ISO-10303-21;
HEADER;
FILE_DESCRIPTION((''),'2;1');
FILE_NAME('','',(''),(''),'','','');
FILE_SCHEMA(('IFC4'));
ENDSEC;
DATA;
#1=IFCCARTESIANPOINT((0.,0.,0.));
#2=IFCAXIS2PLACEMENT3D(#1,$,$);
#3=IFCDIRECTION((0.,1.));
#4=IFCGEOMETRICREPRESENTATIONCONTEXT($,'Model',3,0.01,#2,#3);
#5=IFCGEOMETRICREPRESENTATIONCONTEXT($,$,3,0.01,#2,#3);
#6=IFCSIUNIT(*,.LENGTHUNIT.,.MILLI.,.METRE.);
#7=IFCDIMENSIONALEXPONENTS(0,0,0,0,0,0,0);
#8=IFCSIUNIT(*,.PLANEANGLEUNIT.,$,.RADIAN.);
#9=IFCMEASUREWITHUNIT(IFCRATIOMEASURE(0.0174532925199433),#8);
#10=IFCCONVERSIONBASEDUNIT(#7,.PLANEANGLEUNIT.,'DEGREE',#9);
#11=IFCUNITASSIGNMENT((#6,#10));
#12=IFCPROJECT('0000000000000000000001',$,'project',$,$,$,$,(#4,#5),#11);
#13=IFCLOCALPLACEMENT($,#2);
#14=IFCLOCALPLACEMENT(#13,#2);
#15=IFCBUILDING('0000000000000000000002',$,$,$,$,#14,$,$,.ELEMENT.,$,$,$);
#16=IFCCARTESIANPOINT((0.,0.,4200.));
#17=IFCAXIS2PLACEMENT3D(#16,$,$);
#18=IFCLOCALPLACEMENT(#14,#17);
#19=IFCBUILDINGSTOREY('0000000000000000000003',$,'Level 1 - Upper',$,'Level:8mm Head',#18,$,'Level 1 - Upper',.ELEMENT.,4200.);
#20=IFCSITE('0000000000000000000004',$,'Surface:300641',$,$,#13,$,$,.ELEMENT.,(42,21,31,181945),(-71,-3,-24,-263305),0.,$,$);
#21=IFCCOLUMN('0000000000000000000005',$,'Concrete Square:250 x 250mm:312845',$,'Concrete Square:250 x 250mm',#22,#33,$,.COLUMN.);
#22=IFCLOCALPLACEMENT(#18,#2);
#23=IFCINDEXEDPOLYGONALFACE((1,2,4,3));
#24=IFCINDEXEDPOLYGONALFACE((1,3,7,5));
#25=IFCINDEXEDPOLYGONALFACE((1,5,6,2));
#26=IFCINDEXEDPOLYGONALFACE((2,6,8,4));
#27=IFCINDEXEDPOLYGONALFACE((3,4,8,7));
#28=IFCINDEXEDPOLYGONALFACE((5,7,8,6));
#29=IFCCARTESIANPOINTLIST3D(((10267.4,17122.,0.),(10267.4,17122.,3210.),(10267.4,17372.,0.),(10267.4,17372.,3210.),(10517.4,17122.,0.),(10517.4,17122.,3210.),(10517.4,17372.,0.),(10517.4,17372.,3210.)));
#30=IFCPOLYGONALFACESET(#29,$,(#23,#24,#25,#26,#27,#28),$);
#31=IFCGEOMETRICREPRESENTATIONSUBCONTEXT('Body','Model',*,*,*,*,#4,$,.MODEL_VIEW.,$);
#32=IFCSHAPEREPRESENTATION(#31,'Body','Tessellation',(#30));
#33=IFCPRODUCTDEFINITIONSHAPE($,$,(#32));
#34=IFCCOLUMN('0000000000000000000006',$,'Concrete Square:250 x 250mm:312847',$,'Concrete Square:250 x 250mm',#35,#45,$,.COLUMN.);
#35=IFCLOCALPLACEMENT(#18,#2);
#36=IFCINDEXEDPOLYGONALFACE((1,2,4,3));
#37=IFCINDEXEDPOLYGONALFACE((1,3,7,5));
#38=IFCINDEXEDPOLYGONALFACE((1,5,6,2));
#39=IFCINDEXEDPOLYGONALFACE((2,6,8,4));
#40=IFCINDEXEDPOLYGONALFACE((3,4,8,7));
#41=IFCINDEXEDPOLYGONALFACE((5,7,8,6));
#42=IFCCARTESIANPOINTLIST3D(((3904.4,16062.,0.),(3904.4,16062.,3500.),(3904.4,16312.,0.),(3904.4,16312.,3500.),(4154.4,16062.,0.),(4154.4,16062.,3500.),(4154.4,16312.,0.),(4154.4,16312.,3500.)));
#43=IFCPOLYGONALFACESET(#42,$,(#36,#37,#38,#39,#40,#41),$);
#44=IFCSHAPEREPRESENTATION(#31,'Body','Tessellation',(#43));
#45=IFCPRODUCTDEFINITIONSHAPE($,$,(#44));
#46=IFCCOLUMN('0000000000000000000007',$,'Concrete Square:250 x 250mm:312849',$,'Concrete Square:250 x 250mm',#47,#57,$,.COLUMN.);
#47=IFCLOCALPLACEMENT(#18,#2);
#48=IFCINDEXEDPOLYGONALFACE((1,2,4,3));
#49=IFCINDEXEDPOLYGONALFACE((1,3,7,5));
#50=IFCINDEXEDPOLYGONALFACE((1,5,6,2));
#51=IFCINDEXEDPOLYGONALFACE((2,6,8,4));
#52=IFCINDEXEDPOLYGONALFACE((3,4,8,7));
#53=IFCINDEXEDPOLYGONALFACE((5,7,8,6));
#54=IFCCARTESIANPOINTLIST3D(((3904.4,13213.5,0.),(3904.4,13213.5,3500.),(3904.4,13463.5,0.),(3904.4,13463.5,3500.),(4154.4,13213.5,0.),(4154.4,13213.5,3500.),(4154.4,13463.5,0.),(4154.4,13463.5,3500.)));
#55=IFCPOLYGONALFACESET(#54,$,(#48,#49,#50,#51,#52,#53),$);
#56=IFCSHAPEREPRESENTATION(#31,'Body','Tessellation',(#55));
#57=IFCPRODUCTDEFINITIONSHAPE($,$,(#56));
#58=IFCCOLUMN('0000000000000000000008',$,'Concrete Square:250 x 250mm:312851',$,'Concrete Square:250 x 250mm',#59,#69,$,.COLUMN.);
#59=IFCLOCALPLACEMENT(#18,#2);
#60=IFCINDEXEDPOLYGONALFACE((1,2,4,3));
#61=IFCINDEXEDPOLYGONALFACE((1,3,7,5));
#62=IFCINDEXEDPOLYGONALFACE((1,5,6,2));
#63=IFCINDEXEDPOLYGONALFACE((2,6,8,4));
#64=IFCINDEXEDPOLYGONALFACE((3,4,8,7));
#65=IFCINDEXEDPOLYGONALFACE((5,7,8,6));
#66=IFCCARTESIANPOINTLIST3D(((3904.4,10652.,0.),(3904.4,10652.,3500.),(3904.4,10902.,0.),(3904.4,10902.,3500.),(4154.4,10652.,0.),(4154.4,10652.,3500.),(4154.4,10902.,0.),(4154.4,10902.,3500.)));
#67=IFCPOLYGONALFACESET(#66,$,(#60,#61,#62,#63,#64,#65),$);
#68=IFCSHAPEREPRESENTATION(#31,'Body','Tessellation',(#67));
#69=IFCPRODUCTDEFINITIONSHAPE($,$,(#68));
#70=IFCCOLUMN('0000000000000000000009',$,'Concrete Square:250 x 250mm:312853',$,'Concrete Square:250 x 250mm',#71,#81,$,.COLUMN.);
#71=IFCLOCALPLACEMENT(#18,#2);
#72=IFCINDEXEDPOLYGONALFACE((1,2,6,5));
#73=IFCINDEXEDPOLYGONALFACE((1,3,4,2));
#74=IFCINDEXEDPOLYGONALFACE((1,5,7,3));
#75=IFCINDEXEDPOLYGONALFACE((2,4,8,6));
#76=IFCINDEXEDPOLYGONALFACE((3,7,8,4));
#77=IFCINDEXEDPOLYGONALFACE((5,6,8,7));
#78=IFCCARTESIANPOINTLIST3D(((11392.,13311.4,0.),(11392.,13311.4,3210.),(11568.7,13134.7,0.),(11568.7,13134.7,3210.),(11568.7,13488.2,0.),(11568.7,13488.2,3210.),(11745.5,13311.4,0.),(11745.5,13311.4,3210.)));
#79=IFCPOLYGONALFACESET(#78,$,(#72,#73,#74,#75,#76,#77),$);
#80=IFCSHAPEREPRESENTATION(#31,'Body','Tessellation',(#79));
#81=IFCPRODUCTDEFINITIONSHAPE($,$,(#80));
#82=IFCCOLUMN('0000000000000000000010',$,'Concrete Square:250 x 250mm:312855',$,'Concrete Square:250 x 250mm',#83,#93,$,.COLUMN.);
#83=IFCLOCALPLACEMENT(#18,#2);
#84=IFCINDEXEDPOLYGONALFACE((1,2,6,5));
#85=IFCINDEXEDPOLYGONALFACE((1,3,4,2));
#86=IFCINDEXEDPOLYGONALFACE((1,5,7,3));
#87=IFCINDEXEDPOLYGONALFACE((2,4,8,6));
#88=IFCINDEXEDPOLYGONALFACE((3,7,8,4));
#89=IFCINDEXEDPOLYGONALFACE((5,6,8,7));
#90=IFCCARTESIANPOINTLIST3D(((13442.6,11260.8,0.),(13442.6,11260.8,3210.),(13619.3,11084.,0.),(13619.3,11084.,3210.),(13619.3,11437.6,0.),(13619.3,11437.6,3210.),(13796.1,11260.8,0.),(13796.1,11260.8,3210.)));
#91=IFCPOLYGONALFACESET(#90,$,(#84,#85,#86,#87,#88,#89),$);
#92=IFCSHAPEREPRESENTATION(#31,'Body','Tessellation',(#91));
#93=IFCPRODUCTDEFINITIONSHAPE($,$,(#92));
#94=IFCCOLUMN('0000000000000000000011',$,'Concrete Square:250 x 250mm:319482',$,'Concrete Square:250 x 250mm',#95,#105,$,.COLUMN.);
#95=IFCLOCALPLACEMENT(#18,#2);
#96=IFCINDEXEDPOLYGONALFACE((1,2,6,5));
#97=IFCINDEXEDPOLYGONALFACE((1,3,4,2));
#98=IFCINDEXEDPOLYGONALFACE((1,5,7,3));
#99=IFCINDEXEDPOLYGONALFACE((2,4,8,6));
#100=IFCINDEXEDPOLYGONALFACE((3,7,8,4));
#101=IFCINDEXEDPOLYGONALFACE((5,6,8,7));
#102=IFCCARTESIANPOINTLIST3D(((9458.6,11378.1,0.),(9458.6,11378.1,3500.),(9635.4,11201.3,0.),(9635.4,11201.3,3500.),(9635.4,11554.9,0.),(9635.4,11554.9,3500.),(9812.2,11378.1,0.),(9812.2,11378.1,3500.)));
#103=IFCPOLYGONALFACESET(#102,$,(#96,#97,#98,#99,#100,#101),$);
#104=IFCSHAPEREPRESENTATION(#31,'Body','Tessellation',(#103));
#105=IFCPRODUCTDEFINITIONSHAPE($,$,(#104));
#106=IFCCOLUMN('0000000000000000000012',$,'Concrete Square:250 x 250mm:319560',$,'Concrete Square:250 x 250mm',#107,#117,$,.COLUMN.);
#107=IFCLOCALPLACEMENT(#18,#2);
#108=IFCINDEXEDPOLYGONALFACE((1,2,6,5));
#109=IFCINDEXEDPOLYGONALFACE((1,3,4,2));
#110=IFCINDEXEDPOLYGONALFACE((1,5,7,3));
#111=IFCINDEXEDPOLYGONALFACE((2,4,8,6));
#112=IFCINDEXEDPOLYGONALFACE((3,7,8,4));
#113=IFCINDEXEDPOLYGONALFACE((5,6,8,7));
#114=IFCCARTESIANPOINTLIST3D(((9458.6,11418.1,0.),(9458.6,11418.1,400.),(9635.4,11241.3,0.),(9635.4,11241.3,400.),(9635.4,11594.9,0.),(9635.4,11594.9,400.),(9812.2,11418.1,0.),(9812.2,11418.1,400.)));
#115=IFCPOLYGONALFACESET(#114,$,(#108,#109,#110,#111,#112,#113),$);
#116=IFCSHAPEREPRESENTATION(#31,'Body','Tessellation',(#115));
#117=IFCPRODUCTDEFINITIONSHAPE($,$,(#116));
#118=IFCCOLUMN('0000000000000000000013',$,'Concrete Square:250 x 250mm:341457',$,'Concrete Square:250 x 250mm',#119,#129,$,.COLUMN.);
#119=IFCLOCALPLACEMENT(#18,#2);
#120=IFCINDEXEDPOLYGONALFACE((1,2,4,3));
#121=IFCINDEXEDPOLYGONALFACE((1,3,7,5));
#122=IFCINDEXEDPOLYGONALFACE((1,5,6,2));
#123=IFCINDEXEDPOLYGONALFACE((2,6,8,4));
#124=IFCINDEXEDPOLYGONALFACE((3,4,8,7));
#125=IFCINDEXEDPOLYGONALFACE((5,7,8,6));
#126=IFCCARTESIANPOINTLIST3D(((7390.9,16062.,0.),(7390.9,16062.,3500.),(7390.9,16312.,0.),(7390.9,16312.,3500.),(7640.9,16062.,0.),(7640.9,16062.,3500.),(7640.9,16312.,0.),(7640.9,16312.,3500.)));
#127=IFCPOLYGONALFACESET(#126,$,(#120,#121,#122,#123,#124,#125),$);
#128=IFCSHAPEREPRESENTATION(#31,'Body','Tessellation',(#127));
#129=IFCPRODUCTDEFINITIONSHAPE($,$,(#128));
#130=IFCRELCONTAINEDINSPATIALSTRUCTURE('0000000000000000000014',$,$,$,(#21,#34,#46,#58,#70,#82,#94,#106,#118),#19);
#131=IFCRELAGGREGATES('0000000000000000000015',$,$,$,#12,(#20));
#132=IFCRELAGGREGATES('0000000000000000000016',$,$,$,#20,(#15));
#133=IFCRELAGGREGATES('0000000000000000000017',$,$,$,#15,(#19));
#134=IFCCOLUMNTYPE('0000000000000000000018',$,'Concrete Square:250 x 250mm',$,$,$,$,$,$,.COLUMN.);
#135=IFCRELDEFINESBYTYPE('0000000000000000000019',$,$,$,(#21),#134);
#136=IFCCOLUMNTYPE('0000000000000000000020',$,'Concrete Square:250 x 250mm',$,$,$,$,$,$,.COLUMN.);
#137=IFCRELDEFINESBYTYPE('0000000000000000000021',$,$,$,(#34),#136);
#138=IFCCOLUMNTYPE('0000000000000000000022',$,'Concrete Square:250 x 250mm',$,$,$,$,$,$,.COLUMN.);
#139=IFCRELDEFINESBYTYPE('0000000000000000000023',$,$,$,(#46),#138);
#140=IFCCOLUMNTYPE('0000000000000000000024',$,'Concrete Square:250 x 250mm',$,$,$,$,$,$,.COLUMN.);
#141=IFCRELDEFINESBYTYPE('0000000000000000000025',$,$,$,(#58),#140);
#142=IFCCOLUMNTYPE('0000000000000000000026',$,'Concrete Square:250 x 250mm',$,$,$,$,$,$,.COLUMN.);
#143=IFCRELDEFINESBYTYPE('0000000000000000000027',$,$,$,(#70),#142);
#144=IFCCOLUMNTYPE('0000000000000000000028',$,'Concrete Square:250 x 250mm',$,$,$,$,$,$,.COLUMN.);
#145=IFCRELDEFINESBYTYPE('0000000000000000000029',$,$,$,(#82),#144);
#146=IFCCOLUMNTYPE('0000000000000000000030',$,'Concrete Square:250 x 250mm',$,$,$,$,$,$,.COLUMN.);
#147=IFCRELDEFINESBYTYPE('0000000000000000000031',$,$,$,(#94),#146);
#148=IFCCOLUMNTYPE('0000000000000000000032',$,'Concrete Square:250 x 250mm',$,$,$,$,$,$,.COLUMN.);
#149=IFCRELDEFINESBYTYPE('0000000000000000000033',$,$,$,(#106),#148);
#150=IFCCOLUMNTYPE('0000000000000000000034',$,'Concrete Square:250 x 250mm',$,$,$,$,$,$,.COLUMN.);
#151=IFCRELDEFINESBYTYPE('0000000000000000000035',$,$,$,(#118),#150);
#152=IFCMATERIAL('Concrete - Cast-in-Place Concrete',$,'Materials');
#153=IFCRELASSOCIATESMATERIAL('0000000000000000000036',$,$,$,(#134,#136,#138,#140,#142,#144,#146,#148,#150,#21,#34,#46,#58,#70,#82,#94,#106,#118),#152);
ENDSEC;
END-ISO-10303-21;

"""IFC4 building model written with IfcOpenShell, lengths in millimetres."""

from ifc_helpers import new_model, entity, si_unit, converted_unit, direction, frame, frame_2d, origin, origin_2d_with_axis, place, context, subcontext, project, spatial, rectangle, extrude, source, transform, mapped, material, material_profile, profile_set, profile_usage, type_object, type_shapes, element, save


model = new_model("IFC4")

# Units and contexts
model_context = context("Model", 3, precision=0.01, world=origin(), true_north=direction((0.0, 1.0)))
context_of_model = context(None, 3, precision=0.01, world=origin(), true_north=direction((0.0, 1.0)))
body_context = subcontext(model_context, "Body", "Model", "MODEL_VIEW")
ifc_project = project(units=[si_unit("LENGTHUNIT", "METRE", prefix="MILLI"), converted_unit("PLANEANGLEUNIT", "DEGREE", entity("IfcRatioMeasure", 0.0174532925199433), si_unit("PLANEANGLEUNIT", "RADIAN"), dimensions=[0, 0, 0, 0, 0, 0, 0])], contexts=[model_context, context_of_model])

# Site, building, storey
site_placement = place(None, origin())
site = spatial("IfcSite", under=ifc_project, at=site_placement, Name="Surface:300641", CompositionType="ELEMENT", RefLatitude=(42, 21, 31, 181945), RefLongitude=(-71, -3, -24, -263305), RefElevation=0.0)
building_placement = place(site_placement, origin())
building = spatial("IfcBuilding", under=site, at=building_placement, CompositionType="ELEMENT")
storey_placement = place(building_placement, frame((0.0, 0.0, 4200.0)))
storey = spatial("IfcBuildingStorey", under=building, at=storey_placement, Name="Level 1 - Upper", ObjectType="Level:8mm Head", LongName="Level 1 - Upper", CompositionType="ELEMENT", Elevation=4200.0)

# Columns
ifc_material = material(Name="Concrete - Cast-in-Place Concrete", Category="Materials")
ifc_material_profile_1 = material_profile(ifc_material, rectangle(XDim=250.0, YDim=250.0, at=frame_2d((0.0, 0.0), x_axis=(1.0, 0.0))), Name="250 x 250mm")
ifc_profile_set_1 = profile_set([ifc_material_profile_1], Name="250 x 250mm")
ifc_profile_usage_1 = profile_usage(ifc_profile_set_1)
column_type_1 = type_object("IfcColumnType", Name="Concrete Square:250 x 250mm", PredefinedType="COLUMN", material=ifc_profile_set_1)
shared_shape_1 = source(origin(), body_context, "Body", "SweptSolid", [
    extrude(rectangle(XDim=250.0, YDim=250.0, at=origin_2d_with_axis()), frame((10392.4, 17247.0, 4200.0), z_axis=(0.0, 0.0, 1.0), x_axis=(0.0, -1.0, 0.0)), (0.0, 0.0, 1.0), 3210.0),
])
type_shapes(column_type_1, [shared_shape_1])
column_1_placement = place(storey_placement, frame((0.0, 0.0, -4200.0)))
element("IfcColumn", 1, at=column_1_placement, inside=storey, type_object=column_type_1, material=ifc_profile_usage_1, Name="Concrete Square:250 x 250mm:312845", ObjectType="Concrete Square:250 x 250mm", PredefinedType="COLUMN", context=body_context, shape_type="MappedRepresentation", body=[
    mapped(shared_shape_1, transform((0.0, 0.0, 0.0), scale=1.0)),
])
ifc_profile_usage_2 = profile_usage(ifc_profile_set_1)
column_type_2 = type_object("IfcColumnType", Name="Concrete Square:250 x 250mm", PredefinedType="COLUMN", material=ifc_profile_set_1)
shared_shape_2 = source(origin(), body_context, "Body", "SweptSolid", [
    extrude(rectangle(XDim=250.0, YDim=250.0, at=frame_2d((0.0, 0.0), x_axis=(1.0, 0.0))), frame((4029.4, 16187.0, 4200.0), z_axis=(0.0, 0.0, 1.0), x_axis=(0.0, -1.0, 0.0)), (0.0, 0.0, 1.0), 3500.0),
])
type_shapes(column_type_2, [shared_shape_2])
column_2_placement = place(storey_placement, frame((0.0, 0.0, -4200.0)))
element("IfcColumn", 2, at=column_2_placement, inside=storey, type_object=column_type_2, material=ifc_profile_usage_2, Name="Concrete Square:250 x 250mm:312847", ObjectType="Concrete Square:250 x 250mm", PredefinedType="COLUMN", context=body_context, shape_type="MappedRepresentation", body=[
    mapped(shared_shape_2, transform((0.0, 0.0, 0.0), scale=1.0)),
])
ifc_profile_usage_3 = profile_usage(ifc_profile_set_1)
column_type_3 = type_object("IfcColumnType", Name="Concrete Square:250 x 250mm", PredefinedType="COLUMN", material=ifc_profile_set_1)
shared_shape_3 = source(origin(), body_context, "Body", "SweptSolid", [
    extrude(rectangle(XDim=250.0, YDim=250.0, at=frame_2d((0.0, 0.0), x_axis=(1.0, 0.0))), frame((4029.4, 13338.5, 4200.0), z_axis=(0.0, 0.0, 1.0), x_axis=(0.0, -1.0, 0.0)), (0.0, 0.0, 1.0), 3500.0),
])
type_shapes(column_type_3, [shared_shape_3])
column_3_placement = place(storey_placement, frame((0.0, 0.0, -4200.0)))
element("IfcColumn", 3, at=column_3_placement, inside=storey, type_object=column_type_3, material=ifc_profile_usage_3, Name="Concrete Square:250 x 250mm:312849", ObjectType="Concrete Square:250 x 250mm", PredefinedType="COLUMN", context=body_context, shape_type="MappedRepresentation", body=[
    mapped(shared_shape_3, transform((0.0, 0.0, 0.0), scale=1.0)),
])
ifc_profile_usage_4 = profile_usage(ifc_profile_set_1)
column_type_4 = type_object("IfcColumnType", Name="Concrete Square:250 x 250mm", PredefinedType="COLUMN", material=ifc_profile_set_1)
shared_shape_4 = source(origin(), body_context, "Body", "SweptSolid", [
    extrude(rectangle(XDim=250.0, YDim=250.0, at=frame_2d((0.0, 0.0), x_axis=(1.0, 0.0))), frame((4029.4, 10777.0, 4200.0), z_axis=(0.0, 0.0, 1.0), x_axis=(0.0, -1.0, 0.0)), (0.0, 0.0, 1.0), 3500.0),
])
type_shapes(column_type_4, [shared_shape_4])
column_4_placement = place(storey_placement, frame((0.0, 0.0, -4200.0)))
element("IfcColumn", 4, at=column_4_placement, inside=storey, type_object=column_type_4, material=ifc_profile_usage_4, Name="Concrete Square:250 x 250mm:312851", ObjectType="Concrete Square:250 x 250mm", PredefinedType="COLUMN", context=body_context, shape_type="MappedRepresentation", body=[
    mapped(shared_shape_4, transform((0.0, 0.0, 0.0), scale=1.0)),
])
ifc_profile_usage_5 = profile_usage(ifc_profile_set_1)
column_type_5 = type_object("IfcColumnType", Name="Concrete Square:250 x 250mm", PredefinedType="COLUMN", material=ifc_profile_set_1)
shared_shape_5 = source(origin(), body_context, "Body", "SweptSolid", [
    extrude(rectangle(XDim=250.0, YDim=250.0, at=origin_2d_with_axis()), frame((11568.7, 13311.4, 4200.0), z_axis=(0.0, 0.0, 1.0), x_axis=(-0.707107, 0.707107, 0.0)), (0.0, 0.0, 1.0), 3210.0),
])
type_shapes(column_type_5, [shared_shape_5])
column_5_placement = place(storey_placement, frame((0.0, 0.0, -4200.0)))
element("IfcColumn", 5, at=column_5_placement, inside=storey, type_object=column_type_5, material=ifc_profile_usage_5, Name="Concrete Square:250 x 250mm:312853", ObjectType="Concrete Square:250 x 250mm", PredefinedType="COLUMN", context=body_context, shape_type="MappedRepresentation", body=[
    mapped(shared_shape_5, transform((0.0, 0.0, 0.0), scale=1.0)),
])
ifc_profile_usage_6 = profile_usage(ifc_profile_set_1)
column_type_6 = type_object("IfcColumnType", Name="Concrete Square:250 x 250mm", PredefinedType="COLUMN", material=ifc_profile_set_1)
shared_shape_6 = source(origin(), body_context, "Body", "SweptSolid", [
    extrude(rectangle(XDim=250.0, YDim=250.0, at=frame_2d((0.0, 0.0), x_axis=(1.0, 0.0))), frame((13619.3, 11260.8, 4200.0), z_axis=(0.0, 0.0, 1.0), x_axis=(-0.707107, 0.707107, 0.0)), (0.0, 0.0, 1.0), 3210.0),
])
type_shapes(column_type_6, [shared_shape_6])
column_6_placement = place(storey_placement, frame((0.0, 0.0, -4200.0)))
element("IfcColumn", 6, at=column_6_placement, inside=storey, type_object=column_type_6, material=ifc_profile_usage_6, Name="Concrete Square:250 x 250mm:312855", ObjectType="Concrete Square:250 x 250mm", PredefinedType="COLUMN", context=body_context, shape_type="MappedRepresentation", body=[
    mapped(shared_shape_6, transform((0.0, 0.0, 0.0), scale=1.0)),
])
ifc_profile_usage_7 = profile_usage(ifc_profile_set_1)
column_type_7 = type_object("IfcColumnType", Name="Concrete Square:250 x 250mm", PredefinedType="COLUMN", material=ifc_profile_set_1)
shared_shape_7 = source(origin(), body_context, "Body", "SweptSolid", [
    extrude(rectangle(XDim=250.0, YDim=250.0, at=frame_2d((0.0, 0.0), x_axis=(1.0, 0.0))), frame((9635.4, 11378.1, 4200.0), z_axis=(0.0, 0.0, 1.0), x_axis=(-0.707107, 0.707107, 0.0)), (0.0, 0.0, 1.0), 3500.0),
])
type_shapes(column_type_7, [shared_shape_7])
column_7_placement = place(storey_placement, frame((0.0, 0.0, -4200.0)))
element("IfcColumn", 7, at=column_7_placement, inside=storey, type_object=column_type_7, material=ifc_profile_usage_7, Name="Concrete Square:250 x 250mm:319482", ObjectType="Concrete Square:250 x 250mm", PredefinedType="COLUMN", context=body_context, shape_type="MappedRepresentation", body=[
    mapped(shared_shape_7, transform((0.0, 0.0, 0.0), scale=1.0)),
])
ifc_profile_usage_8 = profile_usage(ifc_profile_set_1)
column_type_8 = type_object("IfcColumnType", Name="Concrete Square:250 x 250mm", PredefinedType="COLUMN", material=ifc_profile_set_1)
shared_shape_8 = source(origin(), body_context, "Body", "SweptSolid", [
    extrude(rectangle(XDim=250.0, YDim=250.0, at=frame_2d((0.0, 0.0), x_axis=(1.0, 0.0))), frame((9635.4, 11418.1, 4200.0), z_axis=(0.0, 0.0, 1.0), x_axis=(-0.707107, 0.707107, 0.0)), (0.0, 0.0, 1.0), 400.0),
])
type_shapes(column_type_8, [shared_shape_8])
column_8_placement = place(storey_placement, frame((0.0, 0.0, -4200.0)))
element("IfcColumn", 8, at=column_8_placement, inside=storey, type_object=column_type_8, material=ifc_profile_usage_8, Name="Concrete Square:250 x 250mm:319560", ObjectType="Concrete Square:250 x 250mm", PredefinedType="COLUMN", context=body_context, shape_type="MappedRepresentation", body=[
    mapped(shared_shape_8, transform((0.0, 0.0, 0.0), scale=1.0)),
])
ifc_profile_usage_9 = profile_usage(ifc_profile_set_1)
column_type_9 = type_object("IfcColumnType", Name="Concrete Square:250 x 250mm", PredefinedType="COLUMN", material=ifc_profile_set_1)
shared_shape_9 = source(origin(), body_context, "Body", "SweptSolid", [
    extrude(rectangle(XDim=250.0, YDim=250.0, at=frame_2d((0.0, 0.0), x_axis=(1.0, 0.0))), frame((7515.9, 16187.0, 4200.0), z_axis=(0.0, 0.0, 1.0), x_axis=(0.0, -1.0, 0.0)), (0.0, 0.0, 1.0), 3500.0),
])
type_shapes(column_type_9, [shared_shape_9])
column_9_placement = place(storey_placement, frame((0.0, 0.0, -4200.0)))
element("IfcColumn", 9, at=column_9_placement, inside=storey, type_object=column_type_9, material=ifc_profile_usage_9, Name="Concrete Square:250 x 250mm:341457", ObjectType="Concrete Square:250 x 250mm", PredefinedType="COLUMN", context=body_context, shape_type="MappedRepresentation", body=[
    mapped(shared_shape_9, transform((0.0, 0.0, 0.0), scale=1.0)),
])

save(model, "model.ifc")
